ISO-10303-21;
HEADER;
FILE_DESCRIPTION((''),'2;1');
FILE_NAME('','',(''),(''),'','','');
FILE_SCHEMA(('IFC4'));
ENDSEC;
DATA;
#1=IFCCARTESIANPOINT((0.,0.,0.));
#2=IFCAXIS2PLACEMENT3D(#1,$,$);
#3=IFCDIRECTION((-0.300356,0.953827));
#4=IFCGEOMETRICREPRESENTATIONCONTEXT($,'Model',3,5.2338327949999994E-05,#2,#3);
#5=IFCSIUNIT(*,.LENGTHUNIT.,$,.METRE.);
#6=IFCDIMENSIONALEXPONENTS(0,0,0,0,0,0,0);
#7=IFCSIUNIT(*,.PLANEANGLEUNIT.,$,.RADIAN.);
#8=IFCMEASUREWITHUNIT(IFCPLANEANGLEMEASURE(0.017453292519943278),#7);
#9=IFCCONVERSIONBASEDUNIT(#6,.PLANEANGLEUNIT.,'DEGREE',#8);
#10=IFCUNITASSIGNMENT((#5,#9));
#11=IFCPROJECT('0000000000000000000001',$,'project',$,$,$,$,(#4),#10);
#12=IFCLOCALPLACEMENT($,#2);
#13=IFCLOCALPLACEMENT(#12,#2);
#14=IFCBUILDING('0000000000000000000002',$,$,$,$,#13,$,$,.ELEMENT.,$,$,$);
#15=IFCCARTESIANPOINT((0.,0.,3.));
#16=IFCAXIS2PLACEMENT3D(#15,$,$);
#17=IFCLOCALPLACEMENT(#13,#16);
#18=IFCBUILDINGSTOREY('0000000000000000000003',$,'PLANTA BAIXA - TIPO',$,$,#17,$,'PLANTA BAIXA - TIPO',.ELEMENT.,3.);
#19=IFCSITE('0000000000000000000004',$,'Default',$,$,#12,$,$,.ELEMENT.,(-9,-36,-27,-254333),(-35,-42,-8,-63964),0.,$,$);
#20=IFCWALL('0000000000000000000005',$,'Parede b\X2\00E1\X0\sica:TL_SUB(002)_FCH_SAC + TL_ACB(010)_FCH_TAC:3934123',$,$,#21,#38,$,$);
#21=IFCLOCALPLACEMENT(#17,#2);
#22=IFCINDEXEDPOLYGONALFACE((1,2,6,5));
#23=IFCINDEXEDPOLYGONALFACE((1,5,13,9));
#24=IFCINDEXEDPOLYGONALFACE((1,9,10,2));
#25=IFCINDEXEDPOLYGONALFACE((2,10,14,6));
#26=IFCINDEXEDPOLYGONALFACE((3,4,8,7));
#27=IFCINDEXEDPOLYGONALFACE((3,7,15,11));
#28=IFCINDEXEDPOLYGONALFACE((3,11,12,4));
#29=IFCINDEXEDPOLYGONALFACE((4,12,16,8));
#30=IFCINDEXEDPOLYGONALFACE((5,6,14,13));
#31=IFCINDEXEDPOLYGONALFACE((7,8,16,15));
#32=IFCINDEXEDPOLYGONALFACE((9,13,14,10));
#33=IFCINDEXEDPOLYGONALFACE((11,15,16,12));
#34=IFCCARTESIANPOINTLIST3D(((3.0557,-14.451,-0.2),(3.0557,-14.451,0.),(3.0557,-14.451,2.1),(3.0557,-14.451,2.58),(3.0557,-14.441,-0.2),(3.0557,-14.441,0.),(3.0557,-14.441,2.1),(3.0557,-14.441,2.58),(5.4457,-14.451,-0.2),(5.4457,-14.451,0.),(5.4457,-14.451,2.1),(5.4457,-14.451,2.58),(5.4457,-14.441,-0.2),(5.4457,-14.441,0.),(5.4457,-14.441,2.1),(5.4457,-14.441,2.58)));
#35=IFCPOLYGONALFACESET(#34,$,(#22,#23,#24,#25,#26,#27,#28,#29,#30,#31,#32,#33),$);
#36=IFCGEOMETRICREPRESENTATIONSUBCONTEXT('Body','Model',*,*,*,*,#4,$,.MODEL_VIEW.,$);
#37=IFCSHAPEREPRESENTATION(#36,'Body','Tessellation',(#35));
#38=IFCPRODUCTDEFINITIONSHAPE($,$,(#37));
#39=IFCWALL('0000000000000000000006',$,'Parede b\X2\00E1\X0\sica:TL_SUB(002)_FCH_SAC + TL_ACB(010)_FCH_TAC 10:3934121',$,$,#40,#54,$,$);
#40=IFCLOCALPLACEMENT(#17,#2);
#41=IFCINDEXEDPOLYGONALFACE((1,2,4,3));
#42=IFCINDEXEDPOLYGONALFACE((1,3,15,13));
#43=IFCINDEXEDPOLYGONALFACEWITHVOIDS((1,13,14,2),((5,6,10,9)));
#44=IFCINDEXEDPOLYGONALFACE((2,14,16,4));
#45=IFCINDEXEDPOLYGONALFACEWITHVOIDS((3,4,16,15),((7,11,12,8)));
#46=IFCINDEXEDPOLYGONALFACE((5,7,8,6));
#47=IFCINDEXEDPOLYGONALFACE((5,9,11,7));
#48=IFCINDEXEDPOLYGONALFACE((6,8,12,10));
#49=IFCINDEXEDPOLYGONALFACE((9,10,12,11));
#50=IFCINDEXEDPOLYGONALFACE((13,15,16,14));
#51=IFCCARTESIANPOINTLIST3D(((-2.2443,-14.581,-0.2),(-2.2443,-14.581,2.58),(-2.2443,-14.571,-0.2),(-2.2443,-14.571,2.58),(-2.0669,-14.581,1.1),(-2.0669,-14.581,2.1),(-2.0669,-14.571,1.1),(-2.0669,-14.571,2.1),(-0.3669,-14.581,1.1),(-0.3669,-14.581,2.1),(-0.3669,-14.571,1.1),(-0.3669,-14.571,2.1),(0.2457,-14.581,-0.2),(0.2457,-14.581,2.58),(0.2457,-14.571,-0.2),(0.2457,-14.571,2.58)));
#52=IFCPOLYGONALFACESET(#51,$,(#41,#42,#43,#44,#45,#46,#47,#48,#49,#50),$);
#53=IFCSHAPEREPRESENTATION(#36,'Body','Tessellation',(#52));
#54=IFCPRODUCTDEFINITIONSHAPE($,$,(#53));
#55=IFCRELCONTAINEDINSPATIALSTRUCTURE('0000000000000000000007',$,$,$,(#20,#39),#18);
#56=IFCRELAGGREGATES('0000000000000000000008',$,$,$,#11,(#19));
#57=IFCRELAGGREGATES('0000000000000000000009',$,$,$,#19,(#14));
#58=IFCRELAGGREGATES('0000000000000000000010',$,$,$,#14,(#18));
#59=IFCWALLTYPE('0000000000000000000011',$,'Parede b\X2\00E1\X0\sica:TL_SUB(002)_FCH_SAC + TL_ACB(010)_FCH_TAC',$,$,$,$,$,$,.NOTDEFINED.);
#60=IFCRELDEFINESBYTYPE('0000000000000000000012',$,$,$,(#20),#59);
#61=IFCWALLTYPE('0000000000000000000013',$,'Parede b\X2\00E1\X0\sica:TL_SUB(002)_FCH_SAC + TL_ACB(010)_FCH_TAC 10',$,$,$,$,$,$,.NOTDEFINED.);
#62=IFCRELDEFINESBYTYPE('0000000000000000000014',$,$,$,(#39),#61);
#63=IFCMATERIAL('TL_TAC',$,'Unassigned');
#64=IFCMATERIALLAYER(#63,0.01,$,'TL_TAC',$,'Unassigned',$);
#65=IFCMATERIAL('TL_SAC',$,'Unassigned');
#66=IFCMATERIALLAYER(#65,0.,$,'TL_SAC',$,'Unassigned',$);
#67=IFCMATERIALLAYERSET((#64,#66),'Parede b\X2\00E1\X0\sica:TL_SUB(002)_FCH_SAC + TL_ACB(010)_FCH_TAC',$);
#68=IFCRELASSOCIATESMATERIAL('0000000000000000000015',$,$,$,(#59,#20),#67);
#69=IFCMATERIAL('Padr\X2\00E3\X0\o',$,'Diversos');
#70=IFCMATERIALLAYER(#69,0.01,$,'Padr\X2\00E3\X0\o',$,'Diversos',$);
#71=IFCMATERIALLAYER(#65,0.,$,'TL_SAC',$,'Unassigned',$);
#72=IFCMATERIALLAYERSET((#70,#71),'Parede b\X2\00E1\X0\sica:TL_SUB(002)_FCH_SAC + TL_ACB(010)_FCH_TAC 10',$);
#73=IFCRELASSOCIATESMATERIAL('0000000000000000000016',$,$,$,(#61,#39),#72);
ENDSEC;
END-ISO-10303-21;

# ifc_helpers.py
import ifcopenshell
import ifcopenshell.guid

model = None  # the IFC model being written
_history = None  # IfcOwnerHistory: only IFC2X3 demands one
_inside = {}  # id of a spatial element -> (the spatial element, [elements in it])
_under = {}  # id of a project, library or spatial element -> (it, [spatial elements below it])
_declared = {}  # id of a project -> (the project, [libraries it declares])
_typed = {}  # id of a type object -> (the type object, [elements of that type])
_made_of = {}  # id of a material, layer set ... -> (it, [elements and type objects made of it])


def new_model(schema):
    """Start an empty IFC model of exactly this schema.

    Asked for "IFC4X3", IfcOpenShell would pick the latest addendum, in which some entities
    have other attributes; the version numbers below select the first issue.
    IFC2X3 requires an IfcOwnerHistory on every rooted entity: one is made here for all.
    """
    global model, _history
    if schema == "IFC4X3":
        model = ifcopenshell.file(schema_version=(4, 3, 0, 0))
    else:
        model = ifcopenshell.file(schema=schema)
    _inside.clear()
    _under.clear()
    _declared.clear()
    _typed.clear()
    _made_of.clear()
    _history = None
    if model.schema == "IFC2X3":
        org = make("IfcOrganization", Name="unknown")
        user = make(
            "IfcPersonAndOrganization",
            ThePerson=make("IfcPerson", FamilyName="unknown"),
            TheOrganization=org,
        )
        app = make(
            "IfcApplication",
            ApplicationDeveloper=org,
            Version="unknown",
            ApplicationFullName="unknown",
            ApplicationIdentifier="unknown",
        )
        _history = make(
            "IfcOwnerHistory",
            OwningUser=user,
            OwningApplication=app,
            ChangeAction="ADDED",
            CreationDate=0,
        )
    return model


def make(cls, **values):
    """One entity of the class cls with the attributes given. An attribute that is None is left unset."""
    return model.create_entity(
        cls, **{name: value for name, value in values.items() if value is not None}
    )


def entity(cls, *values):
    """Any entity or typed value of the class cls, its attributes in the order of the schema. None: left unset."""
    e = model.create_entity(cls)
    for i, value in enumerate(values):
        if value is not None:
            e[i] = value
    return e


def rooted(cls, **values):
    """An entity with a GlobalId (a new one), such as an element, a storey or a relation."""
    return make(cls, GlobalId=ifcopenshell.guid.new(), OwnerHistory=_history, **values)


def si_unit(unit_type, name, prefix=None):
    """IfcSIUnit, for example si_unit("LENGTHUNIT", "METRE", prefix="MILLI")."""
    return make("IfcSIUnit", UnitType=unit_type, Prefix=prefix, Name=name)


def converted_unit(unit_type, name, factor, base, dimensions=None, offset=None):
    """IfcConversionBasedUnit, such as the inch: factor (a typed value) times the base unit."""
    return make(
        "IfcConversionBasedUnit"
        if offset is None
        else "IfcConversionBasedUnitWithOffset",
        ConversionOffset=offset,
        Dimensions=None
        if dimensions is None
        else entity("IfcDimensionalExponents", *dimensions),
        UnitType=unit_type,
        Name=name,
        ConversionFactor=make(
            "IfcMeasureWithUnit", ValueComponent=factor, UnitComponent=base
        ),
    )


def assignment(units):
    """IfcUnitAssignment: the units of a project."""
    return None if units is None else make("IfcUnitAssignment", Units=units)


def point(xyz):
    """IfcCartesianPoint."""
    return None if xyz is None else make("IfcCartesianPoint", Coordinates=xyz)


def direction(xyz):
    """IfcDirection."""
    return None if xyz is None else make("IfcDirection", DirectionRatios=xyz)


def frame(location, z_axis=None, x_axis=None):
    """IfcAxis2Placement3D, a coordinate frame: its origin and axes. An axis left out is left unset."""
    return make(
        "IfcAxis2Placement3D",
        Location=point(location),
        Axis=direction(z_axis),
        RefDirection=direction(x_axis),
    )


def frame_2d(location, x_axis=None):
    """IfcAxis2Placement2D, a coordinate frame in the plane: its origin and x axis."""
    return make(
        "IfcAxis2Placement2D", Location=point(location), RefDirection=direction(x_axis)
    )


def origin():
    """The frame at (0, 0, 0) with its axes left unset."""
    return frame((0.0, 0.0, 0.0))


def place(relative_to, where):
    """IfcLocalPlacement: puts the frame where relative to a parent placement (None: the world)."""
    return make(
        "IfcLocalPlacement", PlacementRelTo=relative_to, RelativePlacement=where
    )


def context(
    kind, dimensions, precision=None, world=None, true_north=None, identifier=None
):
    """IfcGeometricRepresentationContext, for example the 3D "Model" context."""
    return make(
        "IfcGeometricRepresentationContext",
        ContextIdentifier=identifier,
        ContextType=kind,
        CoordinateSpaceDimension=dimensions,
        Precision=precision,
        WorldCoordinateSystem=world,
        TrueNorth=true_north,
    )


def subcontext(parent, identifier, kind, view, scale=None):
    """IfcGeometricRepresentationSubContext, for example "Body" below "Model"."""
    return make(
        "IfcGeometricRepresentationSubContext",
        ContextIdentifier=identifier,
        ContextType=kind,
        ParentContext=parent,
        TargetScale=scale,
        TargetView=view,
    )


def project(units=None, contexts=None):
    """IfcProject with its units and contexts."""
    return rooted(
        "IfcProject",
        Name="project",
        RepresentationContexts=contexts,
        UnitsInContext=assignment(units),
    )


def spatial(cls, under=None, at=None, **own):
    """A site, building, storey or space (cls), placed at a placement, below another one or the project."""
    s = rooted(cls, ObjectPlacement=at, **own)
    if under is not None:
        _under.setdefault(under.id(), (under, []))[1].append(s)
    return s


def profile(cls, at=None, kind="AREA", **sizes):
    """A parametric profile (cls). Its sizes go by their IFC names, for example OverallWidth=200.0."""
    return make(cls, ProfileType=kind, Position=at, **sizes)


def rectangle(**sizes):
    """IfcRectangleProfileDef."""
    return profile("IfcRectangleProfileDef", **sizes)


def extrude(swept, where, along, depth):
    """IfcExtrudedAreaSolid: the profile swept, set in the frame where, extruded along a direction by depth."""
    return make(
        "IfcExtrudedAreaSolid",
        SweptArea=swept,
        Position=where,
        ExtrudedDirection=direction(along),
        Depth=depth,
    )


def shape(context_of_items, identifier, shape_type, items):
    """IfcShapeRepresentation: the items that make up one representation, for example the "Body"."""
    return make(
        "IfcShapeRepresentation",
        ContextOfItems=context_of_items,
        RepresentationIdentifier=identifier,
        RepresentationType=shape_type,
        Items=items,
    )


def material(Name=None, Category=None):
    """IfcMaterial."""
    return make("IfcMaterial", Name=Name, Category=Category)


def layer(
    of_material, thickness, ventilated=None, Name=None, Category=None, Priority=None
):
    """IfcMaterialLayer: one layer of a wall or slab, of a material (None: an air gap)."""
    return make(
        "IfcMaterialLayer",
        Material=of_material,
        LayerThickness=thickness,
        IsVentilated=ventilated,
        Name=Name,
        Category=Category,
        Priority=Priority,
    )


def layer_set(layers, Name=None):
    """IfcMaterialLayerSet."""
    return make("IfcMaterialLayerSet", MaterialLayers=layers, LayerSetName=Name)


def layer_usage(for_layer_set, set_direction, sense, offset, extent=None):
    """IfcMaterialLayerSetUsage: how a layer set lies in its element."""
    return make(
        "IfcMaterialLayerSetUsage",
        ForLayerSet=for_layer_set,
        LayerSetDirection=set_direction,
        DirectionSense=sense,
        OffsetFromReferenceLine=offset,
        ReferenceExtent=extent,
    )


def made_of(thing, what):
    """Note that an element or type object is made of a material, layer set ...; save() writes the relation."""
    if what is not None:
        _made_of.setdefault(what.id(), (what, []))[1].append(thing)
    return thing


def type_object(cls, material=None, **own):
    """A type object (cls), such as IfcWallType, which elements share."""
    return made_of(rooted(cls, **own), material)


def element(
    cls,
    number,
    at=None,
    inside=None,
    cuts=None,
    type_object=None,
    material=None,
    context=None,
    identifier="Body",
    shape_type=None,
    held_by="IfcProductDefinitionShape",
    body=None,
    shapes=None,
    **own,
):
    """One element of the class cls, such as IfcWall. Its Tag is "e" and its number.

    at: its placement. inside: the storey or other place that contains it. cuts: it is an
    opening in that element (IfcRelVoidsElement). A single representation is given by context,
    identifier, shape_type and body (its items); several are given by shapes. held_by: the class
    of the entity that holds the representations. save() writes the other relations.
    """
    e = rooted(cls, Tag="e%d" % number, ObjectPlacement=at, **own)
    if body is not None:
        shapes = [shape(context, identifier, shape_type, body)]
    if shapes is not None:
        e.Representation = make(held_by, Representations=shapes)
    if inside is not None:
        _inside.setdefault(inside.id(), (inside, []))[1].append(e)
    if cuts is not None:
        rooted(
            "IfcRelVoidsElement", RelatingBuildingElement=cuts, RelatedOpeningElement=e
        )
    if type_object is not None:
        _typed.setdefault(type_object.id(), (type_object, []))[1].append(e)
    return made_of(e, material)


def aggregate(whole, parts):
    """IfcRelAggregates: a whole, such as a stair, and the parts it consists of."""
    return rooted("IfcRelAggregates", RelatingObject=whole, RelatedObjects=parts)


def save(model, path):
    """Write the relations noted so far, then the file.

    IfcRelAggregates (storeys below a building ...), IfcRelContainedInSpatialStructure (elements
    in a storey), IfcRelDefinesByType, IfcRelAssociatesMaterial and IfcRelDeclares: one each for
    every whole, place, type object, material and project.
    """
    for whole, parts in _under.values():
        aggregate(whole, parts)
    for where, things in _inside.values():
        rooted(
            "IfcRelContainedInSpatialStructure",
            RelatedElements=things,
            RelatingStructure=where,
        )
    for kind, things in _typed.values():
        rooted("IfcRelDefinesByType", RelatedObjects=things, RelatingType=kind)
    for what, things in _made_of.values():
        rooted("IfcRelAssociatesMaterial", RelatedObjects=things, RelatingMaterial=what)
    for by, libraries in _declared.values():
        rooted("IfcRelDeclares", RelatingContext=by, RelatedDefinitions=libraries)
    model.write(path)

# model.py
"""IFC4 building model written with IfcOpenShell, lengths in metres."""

from ifc_helpers import new_model, entity, si_unit, converted_unit, direction, frame, frame_2d, origin, place, context, subcontext, project, spatial, rectangle, extrude, material, layer, layer_set, layer_usage, type_object, element, save


model = new_model("IFC4")

# Units and contexts
model_context = context("Model", 3, precision=5.2338327949999994e-05, world=origin(), true_north=direction((-0.300356, 0.953827)))
body_context = subcontext(model_context, "Body", "Model", "MODEL_VIEW")
ifc_project = project(units=[si_unit("LENGTHUNIT", "METRE"), converted_unit("PLANEANGLEUNIT", "DEGREE", entity("IfcPlaneAngleMeasure", 0.017453292519943278), si_unit("PLANEANGLEUNIT", "RADIAN"), dimensions=[0, 0, 0, 0, 0, 0, 0])], contexts=[model_context])

# Site, building, storey
site_placement = place(None, origin())
site = spatial("IfcSite", under=ifc_project, at=site_placement, Name="Default", CompositionType="ELEMENT", RefLatitude=(-9, -36, -27, -254333), RefLongitude=(-35, -42, -8, -63964), RefElevation=0.0)
building_placement = place(site_placement, origin())
building = spatial("IfcBuilding", under=site, at=building_placement, CompositionType="ELEMENT")
storey_placement = place(building_placement, frame((0.0, 0.0, 3.0)))
storey = spatial("IfcBuildingStorey", under=building, at=storey_placement, Name="PLANTA BAIXA - TIPO", LongName="PLANTA BAIXA - TIPO", CompositionType="ELEMENT", Elevation=3.0)

# Shared definitions
ifc_material_1 = material(Name="TL_SAC", Category="Unassigned")

# Walls, openings
ifc_material_2 = material(Name="TL_TAC", Category="Unassigned")
ifc_layer_1 = layer(ifc_material_2, 0.01, Name="TL_TAC", Category="Unassigned")
ifc_layer_2 = layer(ifc_material_1, 0.0, Name="TL_SAC", Category="Unassigned")
ifc_layer_set_1 = layer_set([ifc_layer_1, ifc_layer_2], Name="Parede básica:TL_SUB(002)_FCH_SAC + TL_ACB(010)_FCH_TAC")
ifc_layer_usage_1 = layer_usage(ifc_layer_set_1, "AXIS2", "POSITIVE", -0.005)
wall_type_1 = type_object("IfcWallType", Name="Parede básica:TL_SUB(002)_FCH_SAC + TL_ACB(010)_FCH_TAC", PredefinedType="NOTDEFINED", material=ifc_layer_set_1)
wall_1_placement = place(storey_placement, frame((5.4457, -14.446, -0.2), z_axis=(0.0, 0.0, 1.0), x_axis=(-1.0, 0.0, 0.0)))
wall_1 = element("IfcWall", 1, at=wall_1_placement, inside=storey, type_object=wall_type_1, material=ifc_layer_usage_1, Name="Parede básica:TL_SUB(002)_FCH_SAC + TL_ACB(010)_FCH_TAC:3934123", context=body_context, shape_type="SweptSolid", body=[
    extrude(rectangle(XDim=2.39, YDim=0.01, at=frame_2d((1.195, 0.0), x_axis=(-1.0, 0.0))), origin(), (0.0, 0.0, 1.0), 2.78),
])
opening_1_placement = place(wall_1_placement, frame((5.4457, -14.446, 0.2)))
element("IfcOpeningElement", 2, at=opening_1_placement, cuts=wall_1, PredefinedType="OPENING", context=body_context, shape_type="SweptSolid", body=[
    extrude(rectangle(XDim=2.1, YDim=2.4, at=frame_2d((0.0, 0.0), x_axis=(0.0, 1.0))), frame((-4.2557, 12.927, 1.05), z_axis=(0.0, 1.0, 0.0), x_axis=(-1.0, 0.0, 0.0)), (0.0, 0.0, 1.0), 3.048),
])
ifc_material_3 = material(Name="Padrão", Category="Diversos")
ifc_layer_3 = layer(ifc_material_3, 0.01, Name="Padrão", Category="Diversos")
ifc_layer_4 = layer(ifc_material_1, 0.0, Name="TL_SAC", Category="Unassigned")
ifc_layer_set_2 = layer_set([ifc_layer_3, ifc_layer_4], Name="Parede básica:TL_SUB(002)_FCH_SAC + TL_ACB(010)_FCH_TAC 10")
ifc_layer_usage_2 = layer_usage(ifc_layer_set_2, "AXIS2", "NEGATIVE", 0.005)
wall_type_2 = type_object("IfcWallType", Name="Parede básica:TL_SUB(002)_FCH_SAC + TL_ACB(010)_FCH_TAC 10", PredefinedType="NOTDEFINED", material=ifc_layer_set_2)
wall_2_placement = place(storey_placement, frame((0.2457, -14.576, -0.2), z_axis=(0.0, 0.0, 1.0), x_axis=(-1.0, 0.0, 0.0)))
wall_2 = element("IfcWall", 3, at=wall_2_placement, inside=storey, type_object=wall_type_2, material=ifc_layer_usage_2, Name="Parede básica:TL_SUB(002)_FCH_SAC + TL_ACB(010)_FCH_TAC 10:3934121", context=body_context, shape_type="SweptSolid", body=[
    extrude(rectangle(XDim=2.49, YDim=0.01, at=frame_2d((1.245, 0.0), x_axis=(-1.0, 0.0))), origin(), (0.0, 0.0, 1.0), 2.78),
])
opening_2_placement = place(wall_2_placement, frame((0.2457, -14.576, 1.3)))
element("IfcOpeningElement", 4, at=opening_2_placement, cuts=wall_2, PredefinedType="OPENING", context=body_context, shape_type="SweptSolid", body=[
    extrude(rectangle(XDim=1.0, YDim=1.7, at=frame_2d((0.0, 0.0), x_axis=(0.0, 1.0))), frame((1.2169, 13.157, 0.5), z_axis=(0.0, 1.0, 0.0), x_axis=(1.0, 0.0, 0.0)), (0.0, 0.0, 1.0), 3.048),
])

save(model, "model.ifc")
